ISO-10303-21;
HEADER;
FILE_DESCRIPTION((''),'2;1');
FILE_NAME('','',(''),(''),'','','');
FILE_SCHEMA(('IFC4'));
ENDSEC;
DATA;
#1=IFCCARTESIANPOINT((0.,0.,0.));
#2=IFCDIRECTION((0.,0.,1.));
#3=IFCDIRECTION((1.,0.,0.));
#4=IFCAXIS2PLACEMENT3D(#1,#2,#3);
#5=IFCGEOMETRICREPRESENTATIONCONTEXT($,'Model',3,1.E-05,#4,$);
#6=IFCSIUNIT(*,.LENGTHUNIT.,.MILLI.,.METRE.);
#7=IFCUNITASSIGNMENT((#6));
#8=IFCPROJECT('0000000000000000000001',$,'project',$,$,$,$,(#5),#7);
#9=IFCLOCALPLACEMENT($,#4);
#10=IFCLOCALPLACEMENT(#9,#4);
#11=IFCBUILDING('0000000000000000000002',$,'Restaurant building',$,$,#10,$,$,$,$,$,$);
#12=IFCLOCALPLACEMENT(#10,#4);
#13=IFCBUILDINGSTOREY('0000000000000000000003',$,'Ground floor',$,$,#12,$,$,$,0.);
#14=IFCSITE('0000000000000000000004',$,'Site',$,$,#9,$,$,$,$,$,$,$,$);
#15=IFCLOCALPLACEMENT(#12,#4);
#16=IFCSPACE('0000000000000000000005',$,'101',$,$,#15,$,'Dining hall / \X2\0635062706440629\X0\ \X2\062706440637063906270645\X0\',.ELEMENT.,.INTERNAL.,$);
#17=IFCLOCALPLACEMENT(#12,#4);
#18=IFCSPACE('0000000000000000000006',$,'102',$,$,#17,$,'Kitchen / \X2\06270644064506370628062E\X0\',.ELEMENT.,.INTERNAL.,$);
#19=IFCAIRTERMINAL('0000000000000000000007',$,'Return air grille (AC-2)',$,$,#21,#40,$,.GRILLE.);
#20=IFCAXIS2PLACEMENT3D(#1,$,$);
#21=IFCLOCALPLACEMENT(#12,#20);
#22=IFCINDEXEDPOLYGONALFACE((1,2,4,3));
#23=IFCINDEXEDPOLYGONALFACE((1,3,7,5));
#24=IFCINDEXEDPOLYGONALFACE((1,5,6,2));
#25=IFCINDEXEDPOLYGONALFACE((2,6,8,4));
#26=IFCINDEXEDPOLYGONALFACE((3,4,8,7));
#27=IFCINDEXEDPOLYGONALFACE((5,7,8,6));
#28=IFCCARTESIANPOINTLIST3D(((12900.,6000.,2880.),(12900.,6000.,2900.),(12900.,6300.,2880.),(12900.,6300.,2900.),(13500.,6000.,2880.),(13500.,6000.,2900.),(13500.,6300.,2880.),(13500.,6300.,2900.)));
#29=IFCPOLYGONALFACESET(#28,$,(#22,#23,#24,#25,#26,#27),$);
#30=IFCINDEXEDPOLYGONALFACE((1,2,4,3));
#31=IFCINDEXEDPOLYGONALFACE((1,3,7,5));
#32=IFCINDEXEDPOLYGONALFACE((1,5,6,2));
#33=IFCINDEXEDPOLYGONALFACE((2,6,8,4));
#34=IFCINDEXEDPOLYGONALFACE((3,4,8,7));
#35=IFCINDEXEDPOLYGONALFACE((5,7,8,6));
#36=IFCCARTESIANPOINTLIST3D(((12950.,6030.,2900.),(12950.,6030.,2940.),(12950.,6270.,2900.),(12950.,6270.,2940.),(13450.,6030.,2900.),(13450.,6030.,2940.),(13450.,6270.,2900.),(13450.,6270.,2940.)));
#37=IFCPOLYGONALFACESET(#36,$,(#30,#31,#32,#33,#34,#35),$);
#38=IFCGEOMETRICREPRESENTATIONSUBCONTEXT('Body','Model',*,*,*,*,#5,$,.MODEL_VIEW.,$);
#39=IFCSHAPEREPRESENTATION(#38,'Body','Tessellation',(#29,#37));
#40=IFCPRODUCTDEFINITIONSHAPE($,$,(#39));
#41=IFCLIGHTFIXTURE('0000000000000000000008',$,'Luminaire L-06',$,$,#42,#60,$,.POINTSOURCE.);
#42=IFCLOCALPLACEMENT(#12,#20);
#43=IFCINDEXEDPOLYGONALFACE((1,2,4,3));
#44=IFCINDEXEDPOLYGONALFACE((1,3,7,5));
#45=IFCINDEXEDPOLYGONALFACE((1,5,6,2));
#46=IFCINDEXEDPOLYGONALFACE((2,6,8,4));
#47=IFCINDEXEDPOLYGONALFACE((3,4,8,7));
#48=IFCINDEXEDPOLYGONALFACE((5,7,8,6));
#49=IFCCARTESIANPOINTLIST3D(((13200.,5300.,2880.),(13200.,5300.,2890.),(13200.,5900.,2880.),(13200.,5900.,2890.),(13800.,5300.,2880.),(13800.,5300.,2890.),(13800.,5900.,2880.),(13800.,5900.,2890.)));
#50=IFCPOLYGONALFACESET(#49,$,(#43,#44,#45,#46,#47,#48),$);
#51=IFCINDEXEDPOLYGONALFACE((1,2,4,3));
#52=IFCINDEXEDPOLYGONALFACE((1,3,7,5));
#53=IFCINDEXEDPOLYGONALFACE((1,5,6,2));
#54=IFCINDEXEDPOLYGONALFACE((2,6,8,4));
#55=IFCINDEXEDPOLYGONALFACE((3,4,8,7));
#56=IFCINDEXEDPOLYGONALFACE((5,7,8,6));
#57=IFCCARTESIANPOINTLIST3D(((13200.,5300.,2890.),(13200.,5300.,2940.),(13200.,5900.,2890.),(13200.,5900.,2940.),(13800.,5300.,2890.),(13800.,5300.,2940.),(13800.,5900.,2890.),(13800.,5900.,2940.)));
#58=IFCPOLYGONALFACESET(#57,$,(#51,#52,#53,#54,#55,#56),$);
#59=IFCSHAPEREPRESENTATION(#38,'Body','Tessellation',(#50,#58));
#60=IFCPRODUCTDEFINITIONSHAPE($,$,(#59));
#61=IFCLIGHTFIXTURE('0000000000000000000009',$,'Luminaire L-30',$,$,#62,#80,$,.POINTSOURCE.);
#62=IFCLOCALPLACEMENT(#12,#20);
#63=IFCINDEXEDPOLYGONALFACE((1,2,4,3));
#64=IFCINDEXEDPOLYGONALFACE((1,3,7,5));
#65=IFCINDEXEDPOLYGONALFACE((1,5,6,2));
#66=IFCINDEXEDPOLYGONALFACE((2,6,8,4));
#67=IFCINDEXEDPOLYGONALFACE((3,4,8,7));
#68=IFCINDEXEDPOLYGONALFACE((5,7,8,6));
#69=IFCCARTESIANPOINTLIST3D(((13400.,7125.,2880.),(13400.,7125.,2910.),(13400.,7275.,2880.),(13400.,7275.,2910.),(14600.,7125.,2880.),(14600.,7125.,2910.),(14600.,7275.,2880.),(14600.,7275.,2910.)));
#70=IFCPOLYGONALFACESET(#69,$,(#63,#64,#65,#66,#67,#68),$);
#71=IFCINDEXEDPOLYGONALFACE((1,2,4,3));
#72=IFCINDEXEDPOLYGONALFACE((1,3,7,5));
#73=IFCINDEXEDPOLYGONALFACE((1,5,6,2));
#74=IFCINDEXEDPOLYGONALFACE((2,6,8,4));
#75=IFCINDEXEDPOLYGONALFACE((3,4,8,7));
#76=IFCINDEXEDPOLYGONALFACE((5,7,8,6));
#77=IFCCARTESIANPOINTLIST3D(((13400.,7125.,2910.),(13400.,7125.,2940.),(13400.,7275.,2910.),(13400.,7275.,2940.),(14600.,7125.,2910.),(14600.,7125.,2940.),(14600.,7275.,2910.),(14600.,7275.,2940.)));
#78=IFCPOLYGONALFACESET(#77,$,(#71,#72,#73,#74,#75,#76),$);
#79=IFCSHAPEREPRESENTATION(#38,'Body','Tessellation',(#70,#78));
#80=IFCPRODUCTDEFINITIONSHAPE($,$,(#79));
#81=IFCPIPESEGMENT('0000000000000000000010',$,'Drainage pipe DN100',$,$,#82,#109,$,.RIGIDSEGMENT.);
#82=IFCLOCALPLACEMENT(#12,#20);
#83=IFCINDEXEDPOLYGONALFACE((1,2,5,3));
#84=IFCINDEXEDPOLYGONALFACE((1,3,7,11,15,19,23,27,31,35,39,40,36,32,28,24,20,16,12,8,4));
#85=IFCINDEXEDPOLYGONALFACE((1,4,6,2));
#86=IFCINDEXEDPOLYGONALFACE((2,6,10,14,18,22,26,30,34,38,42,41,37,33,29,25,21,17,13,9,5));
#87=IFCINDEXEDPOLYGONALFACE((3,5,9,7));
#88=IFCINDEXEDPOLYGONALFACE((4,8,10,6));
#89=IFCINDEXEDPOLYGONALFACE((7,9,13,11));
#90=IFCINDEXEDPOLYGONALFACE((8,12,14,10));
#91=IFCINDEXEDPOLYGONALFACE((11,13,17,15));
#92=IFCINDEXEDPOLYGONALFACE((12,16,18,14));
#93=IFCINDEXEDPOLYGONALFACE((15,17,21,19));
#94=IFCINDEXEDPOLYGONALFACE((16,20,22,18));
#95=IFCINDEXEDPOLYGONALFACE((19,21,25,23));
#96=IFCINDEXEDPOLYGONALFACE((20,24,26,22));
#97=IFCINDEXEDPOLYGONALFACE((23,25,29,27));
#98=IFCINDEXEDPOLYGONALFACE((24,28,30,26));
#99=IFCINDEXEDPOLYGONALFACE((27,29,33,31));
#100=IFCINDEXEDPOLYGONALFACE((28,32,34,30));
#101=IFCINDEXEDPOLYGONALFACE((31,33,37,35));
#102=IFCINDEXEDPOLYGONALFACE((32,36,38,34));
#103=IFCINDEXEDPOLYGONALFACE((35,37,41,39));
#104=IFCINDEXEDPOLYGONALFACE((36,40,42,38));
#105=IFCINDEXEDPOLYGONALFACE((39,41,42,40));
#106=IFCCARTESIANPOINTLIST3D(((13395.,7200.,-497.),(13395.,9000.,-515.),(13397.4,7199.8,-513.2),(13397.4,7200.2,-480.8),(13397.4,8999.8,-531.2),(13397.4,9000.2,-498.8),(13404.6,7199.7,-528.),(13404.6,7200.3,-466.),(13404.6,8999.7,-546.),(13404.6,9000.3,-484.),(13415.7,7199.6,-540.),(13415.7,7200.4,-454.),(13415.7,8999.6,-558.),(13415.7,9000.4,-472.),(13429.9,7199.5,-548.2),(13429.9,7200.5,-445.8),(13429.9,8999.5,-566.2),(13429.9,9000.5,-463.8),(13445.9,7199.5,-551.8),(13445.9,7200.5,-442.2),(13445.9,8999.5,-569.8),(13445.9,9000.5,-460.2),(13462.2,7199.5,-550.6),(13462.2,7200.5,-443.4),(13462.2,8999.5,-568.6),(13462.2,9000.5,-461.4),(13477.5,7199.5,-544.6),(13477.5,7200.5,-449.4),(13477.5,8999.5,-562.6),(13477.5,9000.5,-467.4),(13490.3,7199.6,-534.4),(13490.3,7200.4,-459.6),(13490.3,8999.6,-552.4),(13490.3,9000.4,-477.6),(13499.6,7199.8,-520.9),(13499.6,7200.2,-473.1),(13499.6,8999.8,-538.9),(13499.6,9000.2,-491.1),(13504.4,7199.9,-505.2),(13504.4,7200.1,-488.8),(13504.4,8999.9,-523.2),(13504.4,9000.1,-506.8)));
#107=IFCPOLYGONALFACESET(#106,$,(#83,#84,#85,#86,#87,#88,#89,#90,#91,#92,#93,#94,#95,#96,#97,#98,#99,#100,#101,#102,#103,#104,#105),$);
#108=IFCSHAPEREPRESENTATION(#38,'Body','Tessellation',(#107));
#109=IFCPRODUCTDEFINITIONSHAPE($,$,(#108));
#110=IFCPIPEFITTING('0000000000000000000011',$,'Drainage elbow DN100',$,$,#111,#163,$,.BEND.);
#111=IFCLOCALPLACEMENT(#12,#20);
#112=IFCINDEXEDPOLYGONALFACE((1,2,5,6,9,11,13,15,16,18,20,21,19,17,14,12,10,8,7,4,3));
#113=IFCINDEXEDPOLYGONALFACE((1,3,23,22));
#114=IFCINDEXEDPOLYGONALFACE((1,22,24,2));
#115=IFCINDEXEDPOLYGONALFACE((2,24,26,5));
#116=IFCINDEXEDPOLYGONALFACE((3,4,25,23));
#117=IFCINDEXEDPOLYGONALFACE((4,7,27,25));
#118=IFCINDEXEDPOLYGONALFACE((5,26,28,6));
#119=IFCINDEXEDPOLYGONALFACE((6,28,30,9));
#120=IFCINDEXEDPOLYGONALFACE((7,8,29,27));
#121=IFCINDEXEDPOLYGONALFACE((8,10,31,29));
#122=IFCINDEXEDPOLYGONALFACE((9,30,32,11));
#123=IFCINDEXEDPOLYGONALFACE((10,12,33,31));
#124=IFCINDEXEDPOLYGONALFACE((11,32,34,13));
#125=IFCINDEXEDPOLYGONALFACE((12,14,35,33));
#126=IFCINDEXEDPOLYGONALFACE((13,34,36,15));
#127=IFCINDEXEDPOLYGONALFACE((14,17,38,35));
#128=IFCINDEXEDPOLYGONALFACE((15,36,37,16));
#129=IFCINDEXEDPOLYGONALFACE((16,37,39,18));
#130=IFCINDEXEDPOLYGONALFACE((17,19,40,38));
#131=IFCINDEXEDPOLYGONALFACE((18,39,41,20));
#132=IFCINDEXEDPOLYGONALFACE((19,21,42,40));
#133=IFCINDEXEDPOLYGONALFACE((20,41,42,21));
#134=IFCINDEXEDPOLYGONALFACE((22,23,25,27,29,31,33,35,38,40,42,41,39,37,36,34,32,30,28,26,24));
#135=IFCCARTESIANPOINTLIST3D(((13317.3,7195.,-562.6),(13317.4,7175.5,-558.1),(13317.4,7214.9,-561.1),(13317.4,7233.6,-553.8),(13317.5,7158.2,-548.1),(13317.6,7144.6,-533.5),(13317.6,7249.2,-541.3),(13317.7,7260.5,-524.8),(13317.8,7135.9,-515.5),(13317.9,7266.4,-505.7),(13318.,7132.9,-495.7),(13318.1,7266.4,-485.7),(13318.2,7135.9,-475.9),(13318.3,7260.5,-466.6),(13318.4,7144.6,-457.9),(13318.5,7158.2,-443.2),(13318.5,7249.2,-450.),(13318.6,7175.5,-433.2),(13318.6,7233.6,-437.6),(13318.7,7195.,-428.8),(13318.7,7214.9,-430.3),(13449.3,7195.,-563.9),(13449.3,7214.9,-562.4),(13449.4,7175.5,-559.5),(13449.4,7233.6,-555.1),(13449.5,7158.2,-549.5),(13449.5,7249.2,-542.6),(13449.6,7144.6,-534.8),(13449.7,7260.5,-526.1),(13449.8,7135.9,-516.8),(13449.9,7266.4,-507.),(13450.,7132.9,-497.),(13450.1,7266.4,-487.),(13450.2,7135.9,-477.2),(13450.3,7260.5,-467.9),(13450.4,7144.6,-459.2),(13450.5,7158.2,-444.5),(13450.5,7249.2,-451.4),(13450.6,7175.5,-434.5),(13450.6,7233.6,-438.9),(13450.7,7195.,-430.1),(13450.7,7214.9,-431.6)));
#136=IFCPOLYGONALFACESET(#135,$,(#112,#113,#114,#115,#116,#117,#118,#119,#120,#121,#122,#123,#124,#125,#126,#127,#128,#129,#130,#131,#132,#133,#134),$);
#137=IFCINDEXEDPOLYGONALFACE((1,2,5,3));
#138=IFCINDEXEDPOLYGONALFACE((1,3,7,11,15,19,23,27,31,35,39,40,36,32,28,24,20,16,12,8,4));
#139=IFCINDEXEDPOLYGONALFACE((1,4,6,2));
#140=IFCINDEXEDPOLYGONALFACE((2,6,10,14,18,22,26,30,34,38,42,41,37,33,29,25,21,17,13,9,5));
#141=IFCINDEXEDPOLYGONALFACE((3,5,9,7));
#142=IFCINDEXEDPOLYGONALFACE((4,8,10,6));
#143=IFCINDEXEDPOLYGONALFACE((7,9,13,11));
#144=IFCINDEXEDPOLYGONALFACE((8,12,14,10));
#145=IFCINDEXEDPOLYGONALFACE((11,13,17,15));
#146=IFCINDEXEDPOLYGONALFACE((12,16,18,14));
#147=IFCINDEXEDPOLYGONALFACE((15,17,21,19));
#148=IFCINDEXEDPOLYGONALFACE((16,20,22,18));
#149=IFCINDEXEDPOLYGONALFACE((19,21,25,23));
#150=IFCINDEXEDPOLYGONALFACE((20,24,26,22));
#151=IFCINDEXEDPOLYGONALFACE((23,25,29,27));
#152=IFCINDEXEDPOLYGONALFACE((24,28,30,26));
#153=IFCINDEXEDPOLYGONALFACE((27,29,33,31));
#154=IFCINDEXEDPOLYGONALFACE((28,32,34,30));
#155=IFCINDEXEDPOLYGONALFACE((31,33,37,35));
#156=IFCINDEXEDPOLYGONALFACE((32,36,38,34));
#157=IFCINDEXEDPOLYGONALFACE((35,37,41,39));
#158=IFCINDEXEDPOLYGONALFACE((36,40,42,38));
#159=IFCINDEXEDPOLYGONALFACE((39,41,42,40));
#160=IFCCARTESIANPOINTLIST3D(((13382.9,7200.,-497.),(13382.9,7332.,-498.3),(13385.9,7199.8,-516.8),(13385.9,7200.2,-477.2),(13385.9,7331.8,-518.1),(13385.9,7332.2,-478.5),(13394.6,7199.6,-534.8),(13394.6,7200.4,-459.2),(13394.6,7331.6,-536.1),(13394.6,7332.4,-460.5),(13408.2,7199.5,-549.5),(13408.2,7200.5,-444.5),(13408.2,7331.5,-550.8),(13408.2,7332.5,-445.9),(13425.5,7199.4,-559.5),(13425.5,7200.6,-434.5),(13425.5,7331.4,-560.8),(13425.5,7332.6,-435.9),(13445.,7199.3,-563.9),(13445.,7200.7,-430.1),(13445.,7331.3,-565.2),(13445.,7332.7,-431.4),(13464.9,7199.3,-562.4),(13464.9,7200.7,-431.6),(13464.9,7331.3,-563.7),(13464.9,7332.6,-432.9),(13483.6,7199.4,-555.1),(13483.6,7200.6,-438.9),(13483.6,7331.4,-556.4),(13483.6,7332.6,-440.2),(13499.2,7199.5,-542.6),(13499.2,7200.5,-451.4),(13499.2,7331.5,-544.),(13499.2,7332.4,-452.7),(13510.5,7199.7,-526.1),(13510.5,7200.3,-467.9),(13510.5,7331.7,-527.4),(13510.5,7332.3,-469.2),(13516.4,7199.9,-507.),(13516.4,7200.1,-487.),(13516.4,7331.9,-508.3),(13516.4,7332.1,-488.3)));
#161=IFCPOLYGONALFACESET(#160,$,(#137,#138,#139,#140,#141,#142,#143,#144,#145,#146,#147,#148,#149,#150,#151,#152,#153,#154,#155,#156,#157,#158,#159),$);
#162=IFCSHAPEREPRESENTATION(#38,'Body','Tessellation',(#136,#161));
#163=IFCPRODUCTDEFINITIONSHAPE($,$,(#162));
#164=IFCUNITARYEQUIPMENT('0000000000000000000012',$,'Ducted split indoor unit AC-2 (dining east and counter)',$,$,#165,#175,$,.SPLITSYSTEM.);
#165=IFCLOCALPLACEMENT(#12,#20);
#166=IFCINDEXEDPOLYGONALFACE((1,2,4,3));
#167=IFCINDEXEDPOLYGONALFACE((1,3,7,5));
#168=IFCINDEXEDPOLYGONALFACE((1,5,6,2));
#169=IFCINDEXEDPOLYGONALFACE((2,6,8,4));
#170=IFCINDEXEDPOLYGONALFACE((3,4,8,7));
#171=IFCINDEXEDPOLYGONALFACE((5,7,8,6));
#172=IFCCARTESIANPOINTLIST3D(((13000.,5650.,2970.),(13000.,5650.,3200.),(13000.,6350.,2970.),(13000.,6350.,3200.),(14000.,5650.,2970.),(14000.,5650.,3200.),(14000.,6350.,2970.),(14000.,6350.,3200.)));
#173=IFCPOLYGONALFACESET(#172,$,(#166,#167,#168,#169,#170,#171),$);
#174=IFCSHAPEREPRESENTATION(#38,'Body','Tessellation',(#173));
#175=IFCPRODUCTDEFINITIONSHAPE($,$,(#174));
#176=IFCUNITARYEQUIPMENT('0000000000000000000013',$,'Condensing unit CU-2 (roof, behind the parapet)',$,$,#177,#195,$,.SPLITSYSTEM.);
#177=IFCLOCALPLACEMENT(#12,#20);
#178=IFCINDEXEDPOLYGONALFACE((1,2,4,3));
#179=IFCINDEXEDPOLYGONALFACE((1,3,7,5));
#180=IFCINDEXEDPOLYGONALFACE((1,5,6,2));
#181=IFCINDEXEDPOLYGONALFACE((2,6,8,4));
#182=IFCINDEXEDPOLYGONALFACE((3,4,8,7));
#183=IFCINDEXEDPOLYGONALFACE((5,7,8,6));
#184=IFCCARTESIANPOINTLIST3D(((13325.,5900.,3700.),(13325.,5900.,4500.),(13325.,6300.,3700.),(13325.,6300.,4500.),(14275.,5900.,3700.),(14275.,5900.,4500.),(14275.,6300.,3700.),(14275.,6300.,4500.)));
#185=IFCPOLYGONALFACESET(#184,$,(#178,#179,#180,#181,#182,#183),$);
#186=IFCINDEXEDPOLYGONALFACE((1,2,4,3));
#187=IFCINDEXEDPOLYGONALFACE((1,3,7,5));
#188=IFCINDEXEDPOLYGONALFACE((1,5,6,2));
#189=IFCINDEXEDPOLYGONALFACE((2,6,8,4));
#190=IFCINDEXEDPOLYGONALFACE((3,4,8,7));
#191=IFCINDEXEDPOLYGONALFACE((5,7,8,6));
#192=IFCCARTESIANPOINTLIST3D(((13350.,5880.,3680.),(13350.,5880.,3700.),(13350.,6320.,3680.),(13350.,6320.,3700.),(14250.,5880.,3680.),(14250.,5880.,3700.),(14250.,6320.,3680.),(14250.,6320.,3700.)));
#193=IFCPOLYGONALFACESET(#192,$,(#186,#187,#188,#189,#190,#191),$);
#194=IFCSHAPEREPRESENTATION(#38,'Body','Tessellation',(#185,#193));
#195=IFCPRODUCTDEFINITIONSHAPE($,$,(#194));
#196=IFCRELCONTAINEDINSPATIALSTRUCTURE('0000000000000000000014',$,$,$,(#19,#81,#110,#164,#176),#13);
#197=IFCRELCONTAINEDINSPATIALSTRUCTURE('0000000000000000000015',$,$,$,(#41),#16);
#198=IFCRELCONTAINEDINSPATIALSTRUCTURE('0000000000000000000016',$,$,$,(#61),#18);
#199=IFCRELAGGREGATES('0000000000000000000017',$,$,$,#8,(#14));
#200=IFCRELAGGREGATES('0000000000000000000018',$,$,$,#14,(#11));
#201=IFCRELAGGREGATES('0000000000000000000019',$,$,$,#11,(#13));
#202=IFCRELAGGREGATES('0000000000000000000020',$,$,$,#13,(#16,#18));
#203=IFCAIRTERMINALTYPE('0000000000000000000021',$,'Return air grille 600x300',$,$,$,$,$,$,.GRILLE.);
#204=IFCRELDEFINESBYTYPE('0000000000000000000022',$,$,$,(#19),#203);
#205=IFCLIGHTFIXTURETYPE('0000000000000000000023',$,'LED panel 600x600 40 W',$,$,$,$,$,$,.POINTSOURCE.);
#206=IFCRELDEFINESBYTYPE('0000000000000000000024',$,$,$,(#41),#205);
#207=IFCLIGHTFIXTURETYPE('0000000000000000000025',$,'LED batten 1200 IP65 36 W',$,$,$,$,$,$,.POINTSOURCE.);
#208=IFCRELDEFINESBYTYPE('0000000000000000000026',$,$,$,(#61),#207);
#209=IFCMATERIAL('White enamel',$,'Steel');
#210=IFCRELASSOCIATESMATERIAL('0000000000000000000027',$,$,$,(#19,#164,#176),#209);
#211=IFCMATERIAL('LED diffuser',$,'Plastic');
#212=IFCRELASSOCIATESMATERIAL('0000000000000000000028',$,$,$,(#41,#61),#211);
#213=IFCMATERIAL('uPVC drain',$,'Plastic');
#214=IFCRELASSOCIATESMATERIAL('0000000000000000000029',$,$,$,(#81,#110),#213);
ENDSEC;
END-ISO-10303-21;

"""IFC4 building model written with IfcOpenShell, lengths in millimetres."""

from ifc_helpers import new_model, si_unit, frame, origin, origin_with_axes, origin_2d, place, context, subcontext, project, spatial, rectangle, circle, extrude, source, transform, mapped, material, type_object, type_shapes, element, save


model = new_model("IFC4")

# Units and contexts
model_context = context("Model", 3, precision=1e-05, world=origin_with_axes())
body_context = subcontext(model_context, "Body", "Model", "MODEL_VIEW")
ifc_project = project(units=[si_unit("LENGTHUNIT", "METRE", prefix="MILLI")], contexts=[model_context])

# Site, building, storey
site_placement = place(None, origin_with_axes())
site = spatial("IfcSite", under=ifc_project, at=site_placement, Name="Site")
building_placement = place(site_placement, origin_with_axes())
building = spatial("IfcBuilding", under=site, at=building_placement, Name="Restaurant building")
storey_placement = place(building_placement, origin_with_axes())
storey = spatial("IfcBuildingStorey", under=building, at=storey_placement, Name="Ground floor", Elevation=0.0)

# Air terminal
ifc_material_1 = material(Name="White enamel", Category="Steel")
air_terminal_type = type_object("IfcAirTerminalType", Name="Return air grille 600x300", PredefinedType="GRILLE")
shared_shape_1 = source(origin(), body_context, "Body", "SweptSolid", [
    extrude(rectangle(XDim=600.0, YDim=300.0, at=origin_2d()), frame((0.0, 0.0, -60.0)), (0.0, 0.0, 1.0), 20.0),
    extrude(rectangle(XDim=500.0, YDim=240.0, at=origin_2d()), frame((0.0, 0.0, -40.0)), (0.0, 0.0, 1.0), 40.0),
])
type_shapes(air_terminal_type, [shared_shape_1])
air_terminal_placement = place(storey_placement, frame((13200.0, 6150.0, 2940.0)))
element("IfcAirTerminal", 1, at=air_terminal_placement, inside=storey, type_object=air_terminal_type, material=ifc_material_1, Name="Return air grille (AC-2)", PredefinedType="GRILLE", context=body_context, shape_type="MappedRepresentation", body=[
    mapped(shared_shape_1, transform((0.0, 0.0, 0.0))),
])

# Shared definitions
space_1_placement = place(storey_placement, origin_with_axes())
space_1 = spatial("IfcSpace", under=storey, at=space_1_placement, Name="101", LongName="Dining hall / صالة الطعام", CompositionType="ELEMENT", PredefinedType="INTERNAL")

# Light fixture
ifc_material_2 = material(Name="LED diffuser", Category="Plastic")
light_fixture_type_1 = type_object("IfcLightFixtureType", Name="LED panel 600x600 40 W", PredefinedType="POINTSOURCE")
shared_shape_2 = source(origin(), body_context, "Body", "SweptSolid", [
    extrude(rectangle(XDim=600.0, YDim=600.0, at=origin_2d()), frame((0.0, 0.0, -60.0)), (0.0, 0.0, 1.0), 10.0),
    extrude(rectangle(XDim=600.0, YDim=600.0, at=origin_2d()), frame((0.0, 0.0, -50.0)), (0.0, 0.0, 1.0), 50.0),
])
type_shapes(light_fixture_type_1, [shared_shape_2])
light_fixture_1_placement = place(storey_placement, frame((13500.0, 5600.0, 2940.0)))
element("IfcLightFixture", 2, at=light_fixture_1_placement, inside=space_1, type_object=light_fixture_type_1, material=ifc_material_2, Name="Luminaire L-06", PredefinedType="POINTSOURCE", context=body_context, shape_type="MappedRepresentation", body=[
    mapped(shared_shape_2, transform((0.0, 0.0, 0.0))),
])

# Shared definitions
space_2_placement = place(storey_placement, origin_with_axes())
space_2 = spatial("IfcSpace", under=storey, at=space_2_placement, Name="102", LongName="Kitchen / المطبخ", CompositionType="ELEMENT", PredefinedType="INTERNAL")

# Light fixture
light_fixture_type_2 = type_object("IfcLightFixtureType", Name="LED batten 1200 IP65 36 W", PredefinedType="POINTSOURCE")
shared_shape_3 = source(origin(), body_context, "Body", "SweptSolid", [
    extrude(rectangle(XDim=1200.0, YDim=150.0, at=origin_2d()), frame((0.0, 0.0, -60.0)), (0.0, 0.0, 1.0), 30.0),
    extrude(rectangle(XDim=1200.0, YDim=150.0, at=origin_2d()), frame((0.0, 0.0, -30.0)), (0.0, 0.0, 1.0), 30.0),
])
type_shapes(light_fixture_type_2, [shared_shape_3])
light_fixture_2_placement = place(storey_placement, frame((14000.0, 7200.0, 2940.0)))
element("IfcLightFixture", 3, at=light_fixture_2_placement, inside=space_2, type_object=light_fixture_type_2, material=ifc_material_2, Name="Luminaire L-30", PredefinedType="POINTSOURCE", context=body_context, shape_type="MappedRepresentation", body=[
    mapped(shared_shape_3, transform((0.0, 0.0, 0.0))),
])

# Pipe segment
ifc_material_3 = material(Name="uPVC drain", Category="Plastic")
pipe_segment_1_placement = place(storey_placement, frame((13450.0, 7200.0, -497.0)))
element("IfcPipeSegment", 4, at=pipe_segment_1_placement, inside=storey, material=ifc_material_3, Name="Drainage pipe DN100", PredefinedType="RIGIDSEGMENT", context=body_context, shape_type="SweptSolid", body=[
    extrude(circle(Radius=55.0, at=origin_2d()), frame((0.0, 0.0, 0.0), z_axis=(0.0, 0.99995, -0.009999), x_axis=(-1.0, 0.0, 0.0)), (0.0, 0.0, 1.0), 1800.1),
])

# Pipe fitting
pipe_fitting_placement = place(storey_placement, frame((13450.0, 7200.0, -497.0)))
element("IfcPipeFitting", 5, at=pipe_fitting_placement, inside=storey, material=ifc_material_3, Name="Drainage elbow DN100", PredefinedType="BEND", context=body_context, shape_type="SweptSolid", body=[
    extrude(circle(Radius=67.1, at=origin_2d()), frame((0.0, 0.0, 0.0), z_axis=(-0.99995, 0.0, 0.009999), x_axis=(0.0, -1.0, 0.0)), (0.0, 0.0, 1.0), 132.0),
    extrude(circle(Radius=67.1, at=origin_2d()), frame((0.0, 0.0, 0.0), z_axis=(0.0, 0.99995, -0.009999), x_axis=(-1.0, 0.0, 0.0)), (0.0, 0.0, 1.0), 132.0),
])

# Unitary equipment
unitary_equipment_1_placement = place(storey_placement, frame((13500.0, 6000.0, 0.0)))
element("IfcUnitaryEquipment", 6, at=unitary_equipment_1_placement, inside=storey, material=ifc_material_1, Name="Ducted split indoor unit AC-2 (dining east and counter)", PredefinedType="SPLITSYSTEM", context=body_context, shape_type="SweptSolid", body=[
    extrude(rectangle(XDim=1000.0, YDim=700.0, at=origin_2d()), frame((0.0, 0.0, 2970.0)), (0.0, 0.0, 1.0), 230.0),
])
unitary_equipment_2_placement = place(storey_placement, frame((13800.0, 6100.0, 0.0)))
element("IfcUnitaryEquipment", 7, at=unitary_equipment_2_placement, inside=storey, material=ifc_material_1, Name="Condensing unit CU-2 (roof, behind the parapet)", PredefinedType="SPLITSYSTEM", context=body_context, shape_type="SweptSolid", body=[
    extrude(rectangle(XDim=950.0, YDim=400.0, at=origin_2d()), frame((0.0, 0.0, 3700.0)), (0.0, 0.0, 1.0), 800.0),
    extrude(rectangle(XDim=900.0, YDim=440.0, at=origin_2d()), frame((0.0, 0.0, 3680.0)), (0.0, 0.0, 1.0), 20.0),
])

save(model, "model.ifc")
